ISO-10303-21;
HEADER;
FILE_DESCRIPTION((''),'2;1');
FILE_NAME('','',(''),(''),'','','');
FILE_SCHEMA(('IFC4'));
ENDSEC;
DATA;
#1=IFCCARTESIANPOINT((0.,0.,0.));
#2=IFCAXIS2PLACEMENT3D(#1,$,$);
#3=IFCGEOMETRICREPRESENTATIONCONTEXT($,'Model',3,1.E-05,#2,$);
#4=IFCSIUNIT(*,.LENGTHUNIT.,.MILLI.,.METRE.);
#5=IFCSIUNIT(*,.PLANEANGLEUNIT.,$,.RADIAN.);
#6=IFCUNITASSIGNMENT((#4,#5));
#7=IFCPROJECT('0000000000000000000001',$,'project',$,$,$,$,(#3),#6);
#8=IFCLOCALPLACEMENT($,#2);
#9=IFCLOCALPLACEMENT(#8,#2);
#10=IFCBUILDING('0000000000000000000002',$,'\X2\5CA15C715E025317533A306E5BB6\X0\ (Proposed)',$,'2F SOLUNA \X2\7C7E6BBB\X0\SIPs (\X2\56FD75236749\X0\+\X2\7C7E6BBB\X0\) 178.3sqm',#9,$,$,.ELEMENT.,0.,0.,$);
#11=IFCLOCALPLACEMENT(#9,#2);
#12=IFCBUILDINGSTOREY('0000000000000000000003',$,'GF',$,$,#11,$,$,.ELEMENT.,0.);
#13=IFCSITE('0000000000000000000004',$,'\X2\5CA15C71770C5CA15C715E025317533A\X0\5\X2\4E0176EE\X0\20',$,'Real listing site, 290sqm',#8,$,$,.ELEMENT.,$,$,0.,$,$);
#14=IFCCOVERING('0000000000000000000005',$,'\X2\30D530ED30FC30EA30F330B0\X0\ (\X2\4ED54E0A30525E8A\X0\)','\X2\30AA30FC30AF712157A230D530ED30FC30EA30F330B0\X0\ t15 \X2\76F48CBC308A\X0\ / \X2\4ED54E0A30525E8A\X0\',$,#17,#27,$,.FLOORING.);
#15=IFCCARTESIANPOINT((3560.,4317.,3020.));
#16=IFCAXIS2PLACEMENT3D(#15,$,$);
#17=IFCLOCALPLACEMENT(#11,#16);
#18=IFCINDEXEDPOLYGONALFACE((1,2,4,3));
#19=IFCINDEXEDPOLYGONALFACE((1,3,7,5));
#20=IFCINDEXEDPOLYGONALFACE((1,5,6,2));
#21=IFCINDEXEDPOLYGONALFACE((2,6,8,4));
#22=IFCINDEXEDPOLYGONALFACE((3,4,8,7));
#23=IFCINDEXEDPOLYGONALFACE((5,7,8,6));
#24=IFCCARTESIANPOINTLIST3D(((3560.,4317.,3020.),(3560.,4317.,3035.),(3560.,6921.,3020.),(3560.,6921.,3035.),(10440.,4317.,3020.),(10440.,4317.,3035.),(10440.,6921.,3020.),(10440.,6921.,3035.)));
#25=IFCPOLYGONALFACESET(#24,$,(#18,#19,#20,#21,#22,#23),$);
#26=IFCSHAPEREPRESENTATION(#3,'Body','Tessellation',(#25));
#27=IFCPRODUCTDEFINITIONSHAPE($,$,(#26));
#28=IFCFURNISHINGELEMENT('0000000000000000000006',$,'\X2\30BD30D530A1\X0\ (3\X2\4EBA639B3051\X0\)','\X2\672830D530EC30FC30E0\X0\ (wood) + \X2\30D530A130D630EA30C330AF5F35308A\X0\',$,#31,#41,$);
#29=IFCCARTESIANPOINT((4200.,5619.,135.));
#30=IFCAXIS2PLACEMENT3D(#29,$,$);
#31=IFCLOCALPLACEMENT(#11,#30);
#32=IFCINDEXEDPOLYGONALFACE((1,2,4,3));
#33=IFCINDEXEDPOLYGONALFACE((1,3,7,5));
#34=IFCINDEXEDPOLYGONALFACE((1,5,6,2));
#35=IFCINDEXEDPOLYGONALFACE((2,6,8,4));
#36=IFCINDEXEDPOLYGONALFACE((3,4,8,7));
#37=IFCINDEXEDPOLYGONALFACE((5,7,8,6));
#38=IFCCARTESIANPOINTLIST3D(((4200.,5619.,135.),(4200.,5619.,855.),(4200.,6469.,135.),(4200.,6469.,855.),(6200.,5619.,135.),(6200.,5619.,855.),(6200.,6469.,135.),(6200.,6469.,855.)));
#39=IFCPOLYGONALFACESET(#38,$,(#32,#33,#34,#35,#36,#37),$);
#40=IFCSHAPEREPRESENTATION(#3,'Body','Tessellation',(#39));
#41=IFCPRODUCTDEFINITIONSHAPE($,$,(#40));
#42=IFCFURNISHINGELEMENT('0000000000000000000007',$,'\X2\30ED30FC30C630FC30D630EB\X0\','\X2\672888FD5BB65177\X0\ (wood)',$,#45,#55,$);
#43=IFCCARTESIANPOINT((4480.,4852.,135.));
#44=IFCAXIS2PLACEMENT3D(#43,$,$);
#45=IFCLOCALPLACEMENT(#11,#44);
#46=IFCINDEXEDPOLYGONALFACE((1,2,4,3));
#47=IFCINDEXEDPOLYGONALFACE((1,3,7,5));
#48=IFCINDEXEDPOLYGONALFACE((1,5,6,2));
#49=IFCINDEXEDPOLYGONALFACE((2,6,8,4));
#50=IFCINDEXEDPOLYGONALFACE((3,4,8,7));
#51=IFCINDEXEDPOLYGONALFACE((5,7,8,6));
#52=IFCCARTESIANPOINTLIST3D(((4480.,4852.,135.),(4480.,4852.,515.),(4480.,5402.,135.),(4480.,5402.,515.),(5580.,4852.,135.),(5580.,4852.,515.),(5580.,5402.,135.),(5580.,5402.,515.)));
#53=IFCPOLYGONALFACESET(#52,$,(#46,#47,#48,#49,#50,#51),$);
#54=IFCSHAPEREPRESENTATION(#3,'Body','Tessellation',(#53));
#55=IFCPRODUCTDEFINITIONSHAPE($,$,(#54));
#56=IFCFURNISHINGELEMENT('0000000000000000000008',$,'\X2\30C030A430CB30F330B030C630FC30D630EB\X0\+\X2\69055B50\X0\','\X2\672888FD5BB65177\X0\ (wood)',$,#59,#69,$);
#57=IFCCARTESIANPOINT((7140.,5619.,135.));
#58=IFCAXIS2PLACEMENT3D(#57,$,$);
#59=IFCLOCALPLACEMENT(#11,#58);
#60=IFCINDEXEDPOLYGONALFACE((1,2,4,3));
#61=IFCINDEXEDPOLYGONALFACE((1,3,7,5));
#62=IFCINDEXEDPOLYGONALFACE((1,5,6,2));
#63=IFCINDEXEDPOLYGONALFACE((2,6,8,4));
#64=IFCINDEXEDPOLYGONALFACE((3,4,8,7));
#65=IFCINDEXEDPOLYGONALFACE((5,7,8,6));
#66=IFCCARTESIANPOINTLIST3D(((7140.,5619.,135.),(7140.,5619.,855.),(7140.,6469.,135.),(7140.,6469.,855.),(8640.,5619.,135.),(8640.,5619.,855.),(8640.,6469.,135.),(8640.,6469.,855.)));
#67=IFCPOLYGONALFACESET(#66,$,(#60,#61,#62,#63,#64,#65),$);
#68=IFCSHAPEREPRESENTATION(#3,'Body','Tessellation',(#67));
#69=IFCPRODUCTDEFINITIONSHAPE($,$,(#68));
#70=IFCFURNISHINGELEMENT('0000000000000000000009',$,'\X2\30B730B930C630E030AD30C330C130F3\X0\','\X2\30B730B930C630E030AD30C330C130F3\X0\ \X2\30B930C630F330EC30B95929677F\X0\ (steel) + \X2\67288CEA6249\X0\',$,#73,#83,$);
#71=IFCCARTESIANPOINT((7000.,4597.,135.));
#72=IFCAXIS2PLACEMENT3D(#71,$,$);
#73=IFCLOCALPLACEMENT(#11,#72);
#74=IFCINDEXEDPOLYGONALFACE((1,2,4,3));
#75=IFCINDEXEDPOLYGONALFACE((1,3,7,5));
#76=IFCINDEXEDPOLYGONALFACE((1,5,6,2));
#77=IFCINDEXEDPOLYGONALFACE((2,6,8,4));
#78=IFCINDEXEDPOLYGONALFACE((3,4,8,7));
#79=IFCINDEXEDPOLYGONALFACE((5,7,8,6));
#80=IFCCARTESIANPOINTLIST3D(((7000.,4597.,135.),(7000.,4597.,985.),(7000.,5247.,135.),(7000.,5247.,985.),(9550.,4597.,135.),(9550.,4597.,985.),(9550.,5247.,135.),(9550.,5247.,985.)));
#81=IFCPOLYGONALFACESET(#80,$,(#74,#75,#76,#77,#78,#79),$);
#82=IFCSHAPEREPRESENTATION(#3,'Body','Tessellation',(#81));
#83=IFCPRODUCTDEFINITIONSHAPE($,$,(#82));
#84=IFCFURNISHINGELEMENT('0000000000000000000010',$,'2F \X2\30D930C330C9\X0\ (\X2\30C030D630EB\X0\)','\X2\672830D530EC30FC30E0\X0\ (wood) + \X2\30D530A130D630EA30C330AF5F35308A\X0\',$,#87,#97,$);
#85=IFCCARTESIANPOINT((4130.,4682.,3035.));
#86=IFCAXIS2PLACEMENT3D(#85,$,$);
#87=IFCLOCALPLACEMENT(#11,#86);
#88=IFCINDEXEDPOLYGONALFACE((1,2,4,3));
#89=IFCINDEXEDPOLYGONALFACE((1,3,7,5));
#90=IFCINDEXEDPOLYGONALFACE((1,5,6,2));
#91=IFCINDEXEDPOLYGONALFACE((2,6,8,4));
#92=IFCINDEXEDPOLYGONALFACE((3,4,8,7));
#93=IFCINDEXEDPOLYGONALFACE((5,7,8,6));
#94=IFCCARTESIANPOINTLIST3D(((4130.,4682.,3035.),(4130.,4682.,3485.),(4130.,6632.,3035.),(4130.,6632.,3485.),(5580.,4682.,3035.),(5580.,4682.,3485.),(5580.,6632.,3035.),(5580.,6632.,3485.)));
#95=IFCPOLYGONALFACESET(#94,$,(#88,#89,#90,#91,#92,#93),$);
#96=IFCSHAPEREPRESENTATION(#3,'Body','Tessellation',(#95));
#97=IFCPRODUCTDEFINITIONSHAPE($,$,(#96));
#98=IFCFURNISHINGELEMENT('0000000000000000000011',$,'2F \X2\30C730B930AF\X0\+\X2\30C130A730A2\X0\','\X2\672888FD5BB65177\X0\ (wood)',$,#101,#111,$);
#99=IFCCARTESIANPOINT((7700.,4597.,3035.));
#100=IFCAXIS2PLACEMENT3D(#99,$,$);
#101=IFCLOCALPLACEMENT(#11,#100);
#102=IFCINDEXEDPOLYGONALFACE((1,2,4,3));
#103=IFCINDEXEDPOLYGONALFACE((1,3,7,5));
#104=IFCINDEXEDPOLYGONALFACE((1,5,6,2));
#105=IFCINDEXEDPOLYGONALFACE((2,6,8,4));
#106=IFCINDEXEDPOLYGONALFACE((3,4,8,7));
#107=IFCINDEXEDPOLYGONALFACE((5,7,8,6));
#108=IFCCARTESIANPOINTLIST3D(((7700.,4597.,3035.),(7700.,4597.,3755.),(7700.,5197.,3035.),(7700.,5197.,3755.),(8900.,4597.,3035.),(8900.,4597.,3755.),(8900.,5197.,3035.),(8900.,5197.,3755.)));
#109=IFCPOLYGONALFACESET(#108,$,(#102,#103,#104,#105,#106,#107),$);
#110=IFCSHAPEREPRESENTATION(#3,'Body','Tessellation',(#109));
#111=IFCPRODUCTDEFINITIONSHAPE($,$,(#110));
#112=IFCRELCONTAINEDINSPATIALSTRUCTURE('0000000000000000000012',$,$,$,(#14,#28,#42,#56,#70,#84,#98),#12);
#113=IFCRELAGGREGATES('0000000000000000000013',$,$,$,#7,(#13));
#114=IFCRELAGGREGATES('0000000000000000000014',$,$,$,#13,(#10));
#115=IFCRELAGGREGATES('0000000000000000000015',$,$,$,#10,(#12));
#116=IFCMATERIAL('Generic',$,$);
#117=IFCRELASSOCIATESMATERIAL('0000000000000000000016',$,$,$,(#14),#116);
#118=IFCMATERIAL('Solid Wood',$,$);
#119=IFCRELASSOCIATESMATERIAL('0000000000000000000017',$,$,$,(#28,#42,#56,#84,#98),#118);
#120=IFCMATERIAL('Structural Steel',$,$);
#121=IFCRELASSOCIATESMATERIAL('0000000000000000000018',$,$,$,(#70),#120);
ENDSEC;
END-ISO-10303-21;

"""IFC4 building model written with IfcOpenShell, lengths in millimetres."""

from ifc_helpers import new_model, si_unit, frame, frame_2d, origin, place, context, project, spatial, rectangle, extrude, material, element, save


model = new_model("IFC4")

# Units and contexts
model_context = context("Model", 3, precision=1e-05, world=origin())
ifc_project = project(units=[si_unit("LENGTHUNIT", "METRE", prefix="MILLI"), si_unit("PLANEANGLEUNIT", "RADIAN")], contexts=[model_context])

# Site, building, storey
site_placement = place(None, origin())
site = spatial("IfcSite", under=ifc_project, at=site_placement, Name="岡山県岡山市北区5丁目20", ObjectType="Real listing site, 290sqm", CompositionType="ELEMENT", RefElevation=0.0)
building_placement = place(site_placement, origin())
building = spatial("IfcBuilding", under=site, at=building_placement, Name="岡山市北区の家 (Proposed)", ObjectType="2F SOLUNA 籾殻SIPs (国産杉+籾殻) 178.3sqm", CompositionType="ELEMENT", ElevationOfRefHeight=0.0, ElevationOfTerrain=0.0)
storey_placement = place(building_placement, origin())
storey = spatial("IfcBuildingStorey", under=building, at=storey_placement, Name="GF", CompositionType="ELEMENT", Elevation=0.0)

# Shared definitions
ifc_material_1 = material(Name="Solid Wood")

# Shared definitions
ifc_material_2 = material(Name="Generic")

# Shared definitions
ifc_material_3 = material(Name="Structural Steel")

# Covering
covering_placement = place(storey_placement, frame((3560.0, 4317.0, 3020.0)))
element("IfcCovering", 1, at=covering_placement, inside=storey, material=ifc_material_2, Name="フローリング (仕上げ床)", Description="オーク無垢フローリング t15 直貼り / 仕上げ床", PredefinedType="FLOORING", context=model_context, shape_type="SweptSolid", body=[
    extrude(rectangle(XDim=6880.0, YDim=2604.0, at=frame_2d((3440.0, 1302.0))), frame((3560.0, 4317.0, 3020.0)), (0.0, 0.0, 1.0), 15.0),
])

# Furnishing elements
furnishing_1_placement = place(storey_placement, frame((4200.0, 5619.0, 135.0)))
element("IfcFurnishingElement", 2, at=furnishing_1_placement, inside=storey, material=ifc_material_1, Name="ソファ (3人掛け)", Description="木フレーム (wood) + ファブリック張り", context=model_context, shape_type="SweptSolid", body=[
    extrude(rectangle(XDim=2000.0, YDim=850.0, at=frame_2d((1000.0, 425.0))), frame((4200.0, 5619.0, 135.0)), (0.0, 0.0, 1.0), 720.0),
])
furnishing_2_placement = place(storey_placement, frame((4480.0, 4852.0, 135.0)))
element("IfcFurnishingElement", 3, at=furnishing_2_placement, inside=storey, material=ifc_material_1, Name="ローテーブル", Description="木製家具 (wood)", context=model_context, shape_type="SweptSolid", body=[
    extrude(rectangle(XDim=1100.0, YDim=550.0, at=frame_2d((550.0, 275.0))), frame((4480.0, 4852.0, 135.0)), (0.0, 0.0, 1.0), 380.0),
])
furnishing_3_placement = place(storey_placement, frame((7140.0, 5619.0, 135.0)))
element("IfcFurnishingElement", 4, at=furnishing_3_placement, inside=storey, material=ifc_material_1, Name="ダイニングテーブル+椅子", Description="木製家具 (wood)", context=model_context, shape_type="SweptSolid", body=[
    extrude(rectangle(XDim=1500.0, YDim=850.0, at=frame_2d((750.0, 425.0))), frame((7140.0, 5619.0, 135.0)), (0.0, 0.0, 1.0), 720.0),
])
furnishing_4_placement = place(storey_placement, frame((7000.0, 4597.0, 135.0)))
element("IfcFurnishingElement", 5, at=furnishing_4_placement, inside=storey, material=ifc_material_3, Name="システムキッチン", Description="システムキッチン ステンレス天板 (steel) + 木質扉", context=model_context, shape_type="SweptSolid", body=[
    extrude(rectangle(XDim=2550.0, YDim=650.0, at=frame_2d((1275.0, 325.0))), frame((7000.0, 4597.0, 135.0)), (0.0, 0.0, 1.0), 850.0),
])
furnishing_5_placement = place(storey_placement, frame((4130.0, 4682.0, 3035.0)))
element("IfcFurnishingElement", 6, at=furnishing_5_placement, inside=storey, material=ifc_material_1, Name="2F ベッド (ダブル)", Description="木フレーム (wood) + ファブリック張り", context=model_context, shape_type="SweptSolid", body=[
    extrude(rectangle(XDim=1450.0, YDim=1950.0, at=frame_2d((725.0, 975.0))), frame((4130.0, 4682.0, 3035.0)), (0.0, 0.0, 1.0), 450.0),
])
furnishing_6_placement = place(storey_placement, frame((7700.0, 4597.0, 3035.0)))
element("IfcFurnishingElement", 7, at=furnishing_6_placement, inside=storey, material=ifc_material_1, Name="2F デスク+チェア", Description="木製家具 (wood)", context=model_context, shape_type="SweptSolid", body=[
    extrude(rectangle(XDim=1200.0, YDim=600.0, at=frame_2d((600.0, 300.0))), frame((7700.0, 4597.0, 3035.0)), (0.0, 0.0, 1.0), 720.0),
])

save(model, "model.ifc")
